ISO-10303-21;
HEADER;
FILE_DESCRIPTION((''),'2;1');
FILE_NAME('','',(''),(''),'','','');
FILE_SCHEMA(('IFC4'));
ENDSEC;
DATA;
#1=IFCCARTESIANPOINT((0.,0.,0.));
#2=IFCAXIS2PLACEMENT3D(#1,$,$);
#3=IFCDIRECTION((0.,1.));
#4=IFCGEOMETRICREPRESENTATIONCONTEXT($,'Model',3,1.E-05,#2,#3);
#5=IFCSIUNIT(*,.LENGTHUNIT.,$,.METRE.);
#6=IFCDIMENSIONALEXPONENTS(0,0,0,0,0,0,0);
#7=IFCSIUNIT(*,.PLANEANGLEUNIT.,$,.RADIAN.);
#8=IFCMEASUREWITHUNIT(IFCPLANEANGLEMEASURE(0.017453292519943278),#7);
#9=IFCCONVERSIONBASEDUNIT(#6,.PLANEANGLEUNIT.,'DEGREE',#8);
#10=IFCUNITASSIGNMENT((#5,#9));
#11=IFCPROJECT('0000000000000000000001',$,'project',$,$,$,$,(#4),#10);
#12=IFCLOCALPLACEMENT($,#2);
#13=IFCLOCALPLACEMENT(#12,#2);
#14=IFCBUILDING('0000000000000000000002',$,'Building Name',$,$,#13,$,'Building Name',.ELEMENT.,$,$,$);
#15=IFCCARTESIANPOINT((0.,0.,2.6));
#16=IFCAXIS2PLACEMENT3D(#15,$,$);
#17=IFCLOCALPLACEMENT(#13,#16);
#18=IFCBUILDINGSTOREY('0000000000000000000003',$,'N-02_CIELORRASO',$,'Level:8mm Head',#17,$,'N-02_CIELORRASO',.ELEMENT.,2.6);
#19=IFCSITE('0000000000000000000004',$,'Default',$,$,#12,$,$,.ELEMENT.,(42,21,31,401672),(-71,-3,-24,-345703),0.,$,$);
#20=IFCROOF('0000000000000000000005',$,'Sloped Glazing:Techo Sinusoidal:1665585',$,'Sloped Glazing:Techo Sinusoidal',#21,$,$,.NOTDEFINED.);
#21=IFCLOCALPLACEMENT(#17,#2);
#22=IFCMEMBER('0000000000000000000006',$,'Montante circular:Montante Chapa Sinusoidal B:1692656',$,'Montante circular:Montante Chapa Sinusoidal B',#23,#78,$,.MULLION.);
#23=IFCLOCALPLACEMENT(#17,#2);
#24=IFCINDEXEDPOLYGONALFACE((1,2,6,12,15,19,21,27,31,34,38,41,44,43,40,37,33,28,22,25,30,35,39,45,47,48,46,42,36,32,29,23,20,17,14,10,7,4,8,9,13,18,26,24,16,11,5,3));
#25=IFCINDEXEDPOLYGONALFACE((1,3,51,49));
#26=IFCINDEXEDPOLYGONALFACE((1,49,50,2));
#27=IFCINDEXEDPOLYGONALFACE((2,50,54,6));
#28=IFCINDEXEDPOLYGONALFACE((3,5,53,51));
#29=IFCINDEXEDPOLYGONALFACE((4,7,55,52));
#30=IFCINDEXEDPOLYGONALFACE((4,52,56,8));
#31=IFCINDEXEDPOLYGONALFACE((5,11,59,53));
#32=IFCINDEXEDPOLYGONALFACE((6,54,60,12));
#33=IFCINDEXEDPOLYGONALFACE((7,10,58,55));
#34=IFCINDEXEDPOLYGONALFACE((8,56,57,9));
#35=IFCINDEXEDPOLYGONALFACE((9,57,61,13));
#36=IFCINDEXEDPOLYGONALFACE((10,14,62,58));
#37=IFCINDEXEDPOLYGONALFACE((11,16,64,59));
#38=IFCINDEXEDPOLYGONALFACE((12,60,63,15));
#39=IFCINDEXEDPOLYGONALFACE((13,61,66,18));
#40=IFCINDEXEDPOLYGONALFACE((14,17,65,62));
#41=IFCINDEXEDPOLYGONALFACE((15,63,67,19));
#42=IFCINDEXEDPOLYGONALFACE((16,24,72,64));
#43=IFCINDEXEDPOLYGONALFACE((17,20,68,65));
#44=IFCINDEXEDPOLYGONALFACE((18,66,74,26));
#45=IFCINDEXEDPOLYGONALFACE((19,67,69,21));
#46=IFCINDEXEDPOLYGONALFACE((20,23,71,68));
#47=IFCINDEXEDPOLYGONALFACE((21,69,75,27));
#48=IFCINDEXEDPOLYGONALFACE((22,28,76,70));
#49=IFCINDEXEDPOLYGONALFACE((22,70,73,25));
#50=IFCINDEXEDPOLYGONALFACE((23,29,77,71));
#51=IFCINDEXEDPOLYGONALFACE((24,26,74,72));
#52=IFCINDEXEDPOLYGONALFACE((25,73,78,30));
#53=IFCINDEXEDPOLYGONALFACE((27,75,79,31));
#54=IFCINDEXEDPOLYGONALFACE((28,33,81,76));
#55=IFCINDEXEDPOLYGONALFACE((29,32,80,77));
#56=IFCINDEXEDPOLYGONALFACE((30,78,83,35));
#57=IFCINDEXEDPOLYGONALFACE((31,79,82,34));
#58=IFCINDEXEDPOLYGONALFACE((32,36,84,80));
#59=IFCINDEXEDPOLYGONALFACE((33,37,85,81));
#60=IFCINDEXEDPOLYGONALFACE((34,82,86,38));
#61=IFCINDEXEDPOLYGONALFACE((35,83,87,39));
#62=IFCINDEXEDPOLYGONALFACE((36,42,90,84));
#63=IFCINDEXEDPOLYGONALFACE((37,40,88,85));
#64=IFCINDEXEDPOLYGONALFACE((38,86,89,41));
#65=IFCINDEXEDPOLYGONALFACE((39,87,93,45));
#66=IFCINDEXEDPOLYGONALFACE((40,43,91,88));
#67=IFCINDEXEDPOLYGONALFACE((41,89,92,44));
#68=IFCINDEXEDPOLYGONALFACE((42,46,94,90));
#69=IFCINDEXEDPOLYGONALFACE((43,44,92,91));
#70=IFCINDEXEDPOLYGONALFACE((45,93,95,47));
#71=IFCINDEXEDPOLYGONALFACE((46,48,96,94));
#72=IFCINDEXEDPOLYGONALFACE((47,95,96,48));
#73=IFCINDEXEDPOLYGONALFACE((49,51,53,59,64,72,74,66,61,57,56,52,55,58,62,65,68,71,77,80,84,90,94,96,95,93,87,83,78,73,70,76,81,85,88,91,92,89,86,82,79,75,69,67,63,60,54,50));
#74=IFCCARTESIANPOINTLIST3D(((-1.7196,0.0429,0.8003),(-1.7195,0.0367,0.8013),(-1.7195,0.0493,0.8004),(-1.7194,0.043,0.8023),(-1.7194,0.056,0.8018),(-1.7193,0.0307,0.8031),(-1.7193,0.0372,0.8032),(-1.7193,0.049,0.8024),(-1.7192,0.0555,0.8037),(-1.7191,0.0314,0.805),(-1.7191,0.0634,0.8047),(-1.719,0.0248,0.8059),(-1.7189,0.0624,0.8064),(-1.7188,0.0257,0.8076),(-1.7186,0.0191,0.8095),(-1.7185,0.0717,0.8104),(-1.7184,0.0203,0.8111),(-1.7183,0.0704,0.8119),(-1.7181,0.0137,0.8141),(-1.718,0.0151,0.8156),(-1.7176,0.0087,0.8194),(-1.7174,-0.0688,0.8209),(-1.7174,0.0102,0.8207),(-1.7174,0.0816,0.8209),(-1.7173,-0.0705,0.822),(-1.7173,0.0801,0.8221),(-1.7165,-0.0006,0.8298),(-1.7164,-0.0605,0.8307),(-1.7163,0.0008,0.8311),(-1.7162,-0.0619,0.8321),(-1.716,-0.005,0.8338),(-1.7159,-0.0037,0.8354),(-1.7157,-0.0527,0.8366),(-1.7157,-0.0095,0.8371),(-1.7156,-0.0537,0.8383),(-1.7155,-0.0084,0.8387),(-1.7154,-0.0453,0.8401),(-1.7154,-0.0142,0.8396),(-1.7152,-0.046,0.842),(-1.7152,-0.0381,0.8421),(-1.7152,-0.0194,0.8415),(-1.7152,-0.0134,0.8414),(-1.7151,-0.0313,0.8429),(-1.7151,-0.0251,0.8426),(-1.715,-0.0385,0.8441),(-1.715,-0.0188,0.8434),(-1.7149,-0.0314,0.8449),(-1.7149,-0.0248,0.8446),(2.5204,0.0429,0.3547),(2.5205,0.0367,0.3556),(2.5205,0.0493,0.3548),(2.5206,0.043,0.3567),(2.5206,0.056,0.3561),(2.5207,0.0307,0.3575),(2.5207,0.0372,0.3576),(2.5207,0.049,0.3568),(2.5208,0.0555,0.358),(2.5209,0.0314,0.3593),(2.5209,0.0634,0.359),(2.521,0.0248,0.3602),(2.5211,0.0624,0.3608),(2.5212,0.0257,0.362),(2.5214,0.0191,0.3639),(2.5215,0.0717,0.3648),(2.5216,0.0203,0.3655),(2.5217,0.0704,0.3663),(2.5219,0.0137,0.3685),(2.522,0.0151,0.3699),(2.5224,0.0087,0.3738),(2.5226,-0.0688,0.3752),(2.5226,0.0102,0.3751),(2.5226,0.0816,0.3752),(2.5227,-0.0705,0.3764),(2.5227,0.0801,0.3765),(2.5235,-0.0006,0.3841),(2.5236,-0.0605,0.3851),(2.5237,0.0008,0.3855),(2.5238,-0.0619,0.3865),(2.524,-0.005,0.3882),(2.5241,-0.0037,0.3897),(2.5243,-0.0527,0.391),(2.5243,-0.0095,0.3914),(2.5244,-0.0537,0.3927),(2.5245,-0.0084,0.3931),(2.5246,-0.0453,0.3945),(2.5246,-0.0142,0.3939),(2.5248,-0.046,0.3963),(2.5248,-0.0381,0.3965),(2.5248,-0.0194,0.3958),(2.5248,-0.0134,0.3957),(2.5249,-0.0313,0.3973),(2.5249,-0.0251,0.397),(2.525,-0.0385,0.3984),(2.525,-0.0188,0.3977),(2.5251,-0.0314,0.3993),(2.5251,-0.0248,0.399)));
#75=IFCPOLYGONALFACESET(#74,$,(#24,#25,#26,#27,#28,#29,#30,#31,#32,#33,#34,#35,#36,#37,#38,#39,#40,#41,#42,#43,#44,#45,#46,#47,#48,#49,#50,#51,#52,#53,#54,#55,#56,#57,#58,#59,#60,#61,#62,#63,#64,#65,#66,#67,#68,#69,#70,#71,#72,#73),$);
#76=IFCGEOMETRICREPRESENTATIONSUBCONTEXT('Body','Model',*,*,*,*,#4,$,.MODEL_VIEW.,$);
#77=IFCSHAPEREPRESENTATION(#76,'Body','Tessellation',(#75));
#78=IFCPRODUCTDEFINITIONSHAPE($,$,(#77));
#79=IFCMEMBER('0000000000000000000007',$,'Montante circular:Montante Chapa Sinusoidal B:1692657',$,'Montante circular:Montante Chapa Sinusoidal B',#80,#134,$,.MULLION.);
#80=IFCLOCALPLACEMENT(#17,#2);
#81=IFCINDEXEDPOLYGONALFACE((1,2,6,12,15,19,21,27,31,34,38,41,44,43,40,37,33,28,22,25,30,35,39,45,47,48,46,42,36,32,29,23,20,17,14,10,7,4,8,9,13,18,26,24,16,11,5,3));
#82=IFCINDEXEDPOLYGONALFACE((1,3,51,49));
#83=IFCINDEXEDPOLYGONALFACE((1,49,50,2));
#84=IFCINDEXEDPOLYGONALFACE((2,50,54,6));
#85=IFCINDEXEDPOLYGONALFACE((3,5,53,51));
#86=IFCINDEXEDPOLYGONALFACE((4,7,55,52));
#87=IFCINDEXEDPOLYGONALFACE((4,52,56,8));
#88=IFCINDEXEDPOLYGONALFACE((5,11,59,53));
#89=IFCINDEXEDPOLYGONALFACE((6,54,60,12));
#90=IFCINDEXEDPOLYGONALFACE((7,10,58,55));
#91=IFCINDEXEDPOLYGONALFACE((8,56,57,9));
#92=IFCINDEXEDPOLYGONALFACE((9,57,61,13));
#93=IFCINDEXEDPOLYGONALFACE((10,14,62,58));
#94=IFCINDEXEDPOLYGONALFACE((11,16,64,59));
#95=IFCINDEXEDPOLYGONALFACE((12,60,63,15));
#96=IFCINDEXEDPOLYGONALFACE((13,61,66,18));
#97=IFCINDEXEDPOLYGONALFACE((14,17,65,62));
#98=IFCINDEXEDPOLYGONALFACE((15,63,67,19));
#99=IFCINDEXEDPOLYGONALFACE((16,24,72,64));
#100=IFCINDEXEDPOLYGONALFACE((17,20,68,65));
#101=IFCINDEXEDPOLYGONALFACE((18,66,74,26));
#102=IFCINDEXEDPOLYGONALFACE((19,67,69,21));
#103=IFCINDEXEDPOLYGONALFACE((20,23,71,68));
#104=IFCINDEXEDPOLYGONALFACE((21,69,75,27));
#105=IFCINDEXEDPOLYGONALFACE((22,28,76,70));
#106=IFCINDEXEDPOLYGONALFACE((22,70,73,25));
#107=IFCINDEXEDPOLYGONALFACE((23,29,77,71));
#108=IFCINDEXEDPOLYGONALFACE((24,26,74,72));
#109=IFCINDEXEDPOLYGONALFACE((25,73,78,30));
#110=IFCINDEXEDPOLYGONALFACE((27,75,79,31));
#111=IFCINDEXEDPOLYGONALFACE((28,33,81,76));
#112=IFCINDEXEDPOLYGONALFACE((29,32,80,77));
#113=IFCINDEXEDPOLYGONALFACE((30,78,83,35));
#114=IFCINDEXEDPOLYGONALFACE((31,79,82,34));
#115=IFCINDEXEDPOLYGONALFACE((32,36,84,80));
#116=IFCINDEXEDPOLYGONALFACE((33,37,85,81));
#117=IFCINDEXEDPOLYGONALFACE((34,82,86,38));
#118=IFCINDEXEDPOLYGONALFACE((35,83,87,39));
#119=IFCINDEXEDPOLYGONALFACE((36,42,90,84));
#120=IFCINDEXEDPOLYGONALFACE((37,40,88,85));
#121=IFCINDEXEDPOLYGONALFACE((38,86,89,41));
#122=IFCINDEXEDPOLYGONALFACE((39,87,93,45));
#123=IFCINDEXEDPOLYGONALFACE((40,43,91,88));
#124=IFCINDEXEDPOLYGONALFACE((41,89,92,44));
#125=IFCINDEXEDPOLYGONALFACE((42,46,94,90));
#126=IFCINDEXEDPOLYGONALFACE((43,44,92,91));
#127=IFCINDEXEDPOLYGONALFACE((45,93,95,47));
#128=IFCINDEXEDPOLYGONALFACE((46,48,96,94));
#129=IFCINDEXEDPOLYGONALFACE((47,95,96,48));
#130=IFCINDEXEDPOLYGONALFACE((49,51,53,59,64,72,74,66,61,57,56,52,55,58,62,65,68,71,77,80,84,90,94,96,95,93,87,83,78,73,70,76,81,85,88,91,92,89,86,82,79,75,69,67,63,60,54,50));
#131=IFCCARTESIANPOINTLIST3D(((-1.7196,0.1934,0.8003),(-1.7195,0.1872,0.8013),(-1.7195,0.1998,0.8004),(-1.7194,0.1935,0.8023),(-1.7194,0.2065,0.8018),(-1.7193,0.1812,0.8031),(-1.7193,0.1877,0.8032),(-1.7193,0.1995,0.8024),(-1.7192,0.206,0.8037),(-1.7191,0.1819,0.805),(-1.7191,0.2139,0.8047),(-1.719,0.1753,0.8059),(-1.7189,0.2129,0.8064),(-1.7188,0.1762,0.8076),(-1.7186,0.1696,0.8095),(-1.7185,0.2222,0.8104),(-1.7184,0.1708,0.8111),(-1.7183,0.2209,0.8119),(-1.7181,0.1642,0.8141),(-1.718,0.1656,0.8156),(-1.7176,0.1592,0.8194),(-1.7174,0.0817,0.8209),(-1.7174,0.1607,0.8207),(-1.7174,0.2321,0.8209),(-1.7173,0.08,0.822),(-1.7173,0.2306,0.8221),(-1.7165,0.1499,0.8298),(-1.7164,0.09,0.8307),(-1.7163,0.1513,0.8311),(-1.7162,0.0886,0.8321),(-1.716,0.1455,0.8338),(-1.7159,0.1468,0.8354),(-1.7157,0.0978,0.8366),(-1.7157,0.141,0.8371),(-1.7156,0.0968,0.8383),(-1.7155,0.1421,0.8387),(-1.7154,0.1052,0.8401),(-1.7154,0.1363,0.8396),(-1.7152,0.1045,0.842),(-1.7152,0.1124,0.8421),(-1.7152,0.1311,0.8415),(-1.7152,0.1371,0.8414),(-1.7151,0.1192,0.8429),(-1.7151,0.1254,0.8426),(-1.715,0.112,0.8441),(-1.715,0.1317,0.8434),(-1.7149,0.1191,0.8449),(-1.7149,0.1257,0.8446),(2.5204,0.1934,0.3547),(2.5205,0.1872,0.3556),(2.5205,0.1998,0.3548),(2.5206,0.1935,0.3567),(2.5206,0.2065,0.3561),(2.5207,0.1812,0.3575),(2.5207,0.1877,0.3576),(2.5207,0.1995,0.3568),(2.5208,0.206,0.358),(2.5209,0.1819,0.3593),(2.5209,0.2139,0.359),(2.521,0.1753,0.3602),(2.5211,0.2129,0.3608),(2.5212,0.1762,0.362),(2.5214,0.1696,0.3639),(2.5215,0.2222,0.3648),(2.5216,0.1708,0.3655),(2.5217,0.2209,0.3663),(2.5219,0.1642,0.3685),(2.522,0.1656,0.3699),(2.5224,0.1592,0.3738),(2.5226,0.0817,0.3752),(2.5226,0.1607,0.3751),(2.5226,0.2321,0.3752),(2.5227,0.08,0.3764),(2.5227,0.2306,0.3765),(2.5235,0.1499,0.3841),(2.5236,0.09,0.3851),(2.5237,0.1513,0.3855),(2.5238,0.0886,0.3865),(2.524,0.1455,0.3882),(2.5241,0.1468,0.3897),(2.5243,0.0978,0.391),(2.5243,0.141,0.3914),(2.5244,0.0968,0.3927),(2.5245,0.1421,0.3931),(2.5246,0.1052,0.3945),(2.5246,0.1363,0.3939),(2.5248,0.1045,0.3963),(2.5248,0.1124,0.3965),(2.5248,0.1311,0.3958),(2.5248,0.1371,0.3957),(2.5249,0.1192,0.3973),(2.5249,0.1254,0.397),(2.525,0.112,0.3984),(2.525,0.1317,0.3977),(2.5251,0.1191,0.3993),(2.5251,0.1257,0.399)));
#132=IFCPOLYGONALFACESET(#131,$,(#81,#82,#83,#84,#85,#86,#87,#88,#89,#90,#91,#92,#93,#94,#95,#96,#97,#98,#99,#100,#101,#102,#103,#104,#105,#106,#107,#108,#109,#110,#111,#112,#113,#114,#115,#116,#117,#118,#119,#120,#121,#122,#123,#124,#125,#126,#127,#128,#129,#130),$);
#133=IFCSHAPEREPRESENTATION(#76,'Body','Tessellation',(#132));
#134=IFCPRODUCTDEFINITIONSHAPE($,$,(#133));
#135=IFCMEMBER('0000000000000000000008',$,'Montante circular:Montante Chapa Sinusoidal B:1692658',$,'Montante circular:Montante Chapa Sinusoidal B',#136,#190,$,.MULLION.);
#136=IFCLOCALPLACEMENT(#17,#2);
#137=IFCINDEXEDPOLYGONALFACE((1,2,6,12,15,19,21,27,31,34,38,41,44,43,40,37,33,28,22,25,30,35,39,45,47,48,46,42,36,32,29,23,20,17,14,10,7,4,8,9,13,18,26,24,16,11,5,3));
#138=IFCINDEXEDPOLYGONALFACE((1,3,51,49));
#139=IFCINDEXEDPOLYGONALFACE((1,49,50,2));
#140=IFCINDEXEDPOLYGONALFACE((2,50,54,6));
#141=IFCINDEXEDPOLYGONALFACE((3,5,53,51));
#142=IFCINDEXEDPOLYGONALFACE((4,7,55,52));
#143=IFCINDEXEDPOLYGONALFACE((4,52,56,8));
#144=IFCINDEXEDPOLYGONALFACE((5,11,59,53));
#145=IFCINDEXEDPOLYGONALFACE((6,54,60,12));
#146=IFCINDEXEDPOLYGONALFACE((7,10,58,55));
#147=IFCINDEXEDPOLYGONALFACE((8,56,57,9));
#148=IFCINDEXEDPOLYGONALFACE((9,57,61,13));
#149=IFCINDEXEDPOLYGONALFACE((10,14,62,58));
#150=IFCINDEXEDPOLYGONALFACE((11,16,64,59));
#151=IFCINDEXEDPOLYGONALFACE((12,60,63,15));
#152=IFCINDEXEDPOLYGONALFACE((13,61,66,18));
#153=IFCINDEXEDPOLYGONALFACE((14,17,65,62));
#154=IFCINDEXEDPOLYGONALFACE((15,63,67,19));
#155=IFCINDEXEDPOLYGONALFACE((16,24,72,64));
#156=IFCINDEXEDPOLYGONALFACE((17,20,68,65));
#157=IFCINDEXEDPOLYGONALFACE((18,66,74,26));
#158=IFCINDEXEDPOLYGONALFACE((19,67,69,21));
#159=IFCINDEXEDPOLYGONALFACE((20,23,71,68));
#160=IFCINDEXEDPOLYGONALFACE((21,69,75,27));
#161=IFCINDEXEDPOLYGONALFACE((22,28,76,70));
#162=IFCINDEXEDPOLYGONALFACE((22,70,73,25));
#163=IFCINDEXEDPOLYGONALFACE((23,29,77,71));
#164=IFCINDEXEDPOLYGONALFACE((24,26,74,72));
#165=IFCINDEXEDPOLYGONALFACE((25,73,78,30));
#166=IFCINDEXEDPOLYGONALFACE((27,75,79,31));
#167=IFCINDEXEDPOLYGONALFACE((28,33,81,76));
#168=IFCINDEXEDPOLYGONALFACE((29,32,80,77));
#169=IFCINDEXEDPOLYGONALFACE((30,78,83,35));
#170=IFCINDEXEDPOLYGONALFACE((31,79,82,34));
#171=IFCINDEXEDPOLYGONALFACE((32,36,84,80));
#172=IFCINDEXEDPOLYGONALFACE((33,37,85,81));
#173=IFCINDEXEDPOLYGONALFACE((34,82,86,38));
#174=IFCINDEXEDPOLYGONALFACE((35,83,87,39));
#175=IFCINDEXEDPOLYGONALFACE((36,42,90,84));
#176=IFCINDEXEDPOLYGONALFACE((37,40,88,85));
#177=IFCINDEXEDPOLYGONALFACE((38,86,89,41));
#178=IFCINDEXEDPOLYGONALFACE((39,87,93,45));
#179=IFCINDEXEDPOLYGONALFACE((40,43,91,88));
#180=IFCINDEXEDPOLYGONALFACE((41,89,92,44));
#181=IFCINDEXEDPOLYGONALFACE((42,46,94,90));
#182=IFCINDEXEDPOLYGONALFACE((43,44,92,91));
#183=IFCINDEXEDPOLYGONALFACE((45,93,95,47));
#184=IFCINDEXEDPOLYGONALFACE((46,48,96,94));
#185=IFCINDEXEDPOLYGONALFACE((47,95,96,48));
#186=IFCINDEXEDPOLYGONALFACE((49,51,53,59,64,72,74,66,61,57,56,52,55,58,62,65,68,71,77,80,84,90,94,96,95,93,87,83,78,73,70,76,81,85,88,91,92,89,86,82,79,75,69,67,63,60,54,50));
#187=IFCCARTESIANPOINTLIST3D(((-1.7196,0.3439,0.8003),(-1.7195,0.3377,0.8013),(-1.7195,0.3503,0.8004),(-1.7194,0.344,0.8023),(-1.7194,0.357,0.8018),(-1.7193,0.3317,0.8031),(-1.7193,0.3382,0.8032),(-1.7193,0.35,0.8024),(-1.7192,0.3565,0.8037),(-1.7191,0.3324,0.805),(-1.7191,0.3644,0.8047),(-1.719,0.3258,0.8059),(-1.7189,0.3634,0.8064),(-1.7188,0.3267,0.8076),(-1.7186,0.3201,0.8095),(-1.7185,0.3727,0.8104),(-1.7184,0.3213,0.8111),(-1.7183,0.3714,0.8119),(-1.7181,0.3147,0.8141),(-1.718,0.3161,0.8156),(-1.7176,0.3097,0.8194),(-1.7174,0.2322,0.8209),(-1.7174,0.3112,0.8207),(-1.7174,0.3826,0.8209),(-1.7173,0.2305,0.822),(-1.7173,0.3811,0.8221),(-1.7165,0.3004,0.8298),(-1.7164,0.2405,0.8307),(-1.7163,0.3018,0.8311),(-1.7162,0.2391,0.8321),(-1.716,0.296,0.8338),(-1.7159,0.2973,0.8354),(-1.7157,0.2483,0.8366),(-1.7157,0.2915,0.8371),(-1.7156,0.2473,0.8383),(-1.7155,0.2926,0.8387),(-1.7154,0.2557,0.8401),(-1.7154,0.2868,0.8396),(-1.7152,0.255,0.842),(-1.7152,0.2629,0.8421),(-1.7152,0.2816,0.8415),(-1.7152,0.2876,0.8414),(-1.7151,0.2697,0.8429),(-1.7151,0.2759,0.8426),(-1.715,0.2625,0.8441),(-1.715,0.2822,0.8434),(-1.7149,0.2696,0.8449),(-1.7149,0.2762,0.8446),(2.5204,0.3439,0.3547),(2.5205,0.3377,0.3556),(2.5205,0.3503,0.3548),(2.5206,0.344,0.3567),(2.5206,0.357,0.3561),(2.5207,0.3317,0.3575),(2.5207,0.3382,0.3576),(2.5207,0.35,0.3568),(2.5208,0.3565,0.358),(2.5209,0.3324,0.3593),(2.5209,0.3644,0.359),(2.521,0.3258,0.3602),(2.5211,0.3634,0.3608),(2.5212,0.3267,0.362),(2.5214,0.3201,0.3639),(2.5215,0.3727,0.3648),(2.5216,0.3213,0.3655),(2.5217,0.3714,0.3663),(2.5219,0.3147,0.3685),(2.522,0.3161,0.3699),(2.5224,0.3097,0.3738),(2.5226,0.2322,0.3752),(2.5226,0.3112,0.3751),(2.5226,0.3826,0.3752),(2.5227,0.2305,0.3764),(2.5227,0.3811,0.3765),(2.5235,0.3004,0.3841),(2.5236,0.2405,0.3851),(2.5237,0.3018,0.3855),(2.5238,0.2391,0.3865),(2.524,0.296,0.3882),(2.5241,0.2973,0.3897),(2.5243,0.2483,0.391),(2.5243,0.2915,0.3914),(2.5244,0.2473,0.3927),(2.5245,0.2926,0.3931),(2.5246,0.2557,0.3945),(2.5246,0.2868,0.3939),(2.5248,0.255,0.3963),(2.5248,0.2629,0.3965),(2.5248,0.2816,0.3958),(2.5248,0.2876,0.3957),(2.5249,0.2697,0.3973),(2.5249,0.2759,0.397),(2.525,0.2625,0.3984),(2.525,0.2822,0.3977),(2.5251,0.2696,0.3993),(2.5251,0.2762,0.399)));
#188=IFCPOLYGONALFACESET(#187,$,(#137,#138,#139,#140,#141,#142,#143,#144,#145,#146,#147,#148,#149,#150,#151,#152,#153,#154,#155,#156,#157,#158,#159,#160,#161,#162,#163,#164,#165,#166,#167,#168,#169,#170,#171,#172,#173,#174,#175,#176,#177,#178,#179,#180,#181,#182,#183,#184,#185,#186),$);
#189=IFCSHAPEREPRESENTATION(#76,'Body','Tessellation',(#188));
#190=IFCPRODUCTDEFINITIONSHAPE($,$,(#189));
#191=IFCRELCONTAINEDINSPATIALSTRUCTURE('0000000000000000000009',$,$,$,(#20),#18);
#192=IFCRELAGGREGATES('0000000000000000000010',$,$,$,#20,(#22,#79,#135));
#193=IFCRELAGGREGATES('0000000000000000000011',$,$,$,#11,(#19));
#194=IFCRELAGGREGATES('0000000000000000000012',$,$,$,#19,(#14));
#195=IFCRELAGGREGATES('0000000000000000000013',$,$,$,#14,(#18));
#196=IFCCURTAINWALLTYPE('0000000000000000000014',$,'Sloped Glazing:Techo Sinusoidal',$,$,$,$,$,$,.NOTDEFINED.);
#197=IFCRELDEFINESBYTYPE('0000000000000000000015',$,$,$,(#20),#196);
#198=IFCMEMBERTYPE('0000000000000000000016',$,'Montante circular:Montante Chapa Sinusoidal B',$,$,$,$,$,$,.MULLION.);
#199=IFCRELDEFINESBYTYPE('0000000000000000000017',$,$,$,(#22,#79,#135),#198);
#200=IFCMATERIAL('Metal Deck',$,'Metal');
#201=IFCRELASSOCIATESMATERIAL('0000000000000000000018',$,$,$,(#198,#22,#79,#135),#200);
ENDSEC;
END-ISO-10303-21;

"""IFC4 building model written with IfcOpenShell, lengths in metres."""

from ifc_helpers import new_model, entity, si_unit, converted_unit, direction, frame, origin, place, context, subcontext, project, spatial, indexed_curve, outline, extrude, source, transform, mapped, material, type_object, type_shapes, element, aggregate, save


model = new_model("IFC4")

# Units and contexts
model_context = context("Model", 3, precision=1e-05, world=origin(), true_north=direction((0.0, 1.0)))
body_context = subcontext(model_context, "Body", "Model", "MODEL_VIEW")
ifc_project = project(units=[si_unit("LENGTHUNIT", "METRE"), converted_unit("PLANEANGLEUNIT", "DEGREE", entity("IfcPlaneAngleMeasure", 0.017453292519943278), si_unit("PLANEANGLEUNIT", "RADIAN"), dimensions=[0, 0, 0, 0, 0, 0, 0])], contexts=[model_context])

# Site, building, storey
site_placement = place(None, origin())
site = spatial("IfcSite", under=ifc_project, at=site_placement, Name="Default", CompositionType="ELEMENT", RefLatitude=(42, 21, 31, 401672), RefLongitude=(-71, -3, -24, -345703), RefElevation=0.0)
building_placement = place(site_placement, origin())
building = spatial("IfcBuilding", under=site, at=building_placement, Name="Building Name", LongName="Building Name", CompositionType="ELEMENT")
storey_placement = place(building_placement, frame((0.0, 0.0, 2.6)))
storey = spatial("IfcBuildingStorey", under=building, at=storey_placement, Name="N-02_CIELORRASO", ObjectType="Level:8mm Head", LongName="N-02_CIELORRASO", CompositionType="ELEMENT", Elevation=2.6)

# Roof, members
curtain_wall_type = type_object("IfcCurtainWallType", Name="Sloped Glazing:Techo Sinusoidal", PredefinedType="NOTDEFINED")
roof_placement = place(storey_placement, frame((0.0, 0.0, -2.6)))
roof = element("IfcRoof", 1, at=roof_placement, inside=storey, type_object=curtain_wall_type, Name="Sloped Glazing:Techo Sinusoidal:1665585", ObjectType="Sloped Glazing:Techo Sinusoidal", PredefinedType="NOTDEFINED")
ifc_material = material(Name="Metal Deck", Category="Metal")
member_type = type_object("IfcMemberType", Name="Montante circular:Montante Chapa Sinusoidal B", PredefinedType="MULLION", material=ifc_material)
shared_shape = source(origin(), body_context, "Body", "SweptSolid", [
    extrude(outline(indexed_curve([(0.0595, -0.0443), (0.0615, -0.0443), (0.0603, -0.031), (0.0572, -0.0213), (0.053, -0.0138), (0.0481, -0.0078), (0.0427, -0.003), (0.0372, 0.0005), (0.0315, 0.0029), (0.0259, 0.0044), (0.0203, 0.0051), (0.0146, 0.005), (0.0084, 0.0041), (-0.0053, 0.0009), (-0.0123, -0.0005), (-0.0191, -0.0012), (-0.0256, -0.001), (-0.0317, 0.0001), (-0.0375, 0.0019), (-0.0428, 0.0046), (-0.0477, 0.0081), (-0.0522, 0.0128), (-0.0563, 0.0191), (-0.0597, 0.0282), (-0.0617, 0.0421), (-0.0637, 0.042), (-0.0616, 0.0277), (-0.0581, 0.0182), (-0.0537, 0.0116), (-0.049, 0.0066), (-0.0438, 0.0028), (-0.0382, 0.0001), (-0.0322, -0.0019), (-0.0258, -0.003), (-0.019, -0.0032), (-0.012, -0.0025), (-0.0048, -0.0011), (0.0088, 0.0021), (0.0147, 0.003), (0.0202, 0.0031), (0.0255, 0.0024), (0.0309, 0.001), (0.0362, -0.0013), (0.0415, -0.0046), (0.0466, -0.0092), (0.0513, -0.0149), (0.0554, -0.0221), (0.0584, -0.0314), (0.0595, -0.0443)], self_intersect=False)), frame((-0.007, 0.0228, -4.2634), z_axis=(0.0, 0.0, 1.0), x_axis=(-0.819152, -0.573576, 0.0)), (0.0, 0.0, 1.0), 4.2634),
])
type_shapes(member_type, [shared_shape])
member_1_placement = place(roof_placement, frame((-1.7148, 0.0124, 3.4456), z_axis=(-0.994522, 0.0, 0.104528), x_axis=(0.0, 1.0, 0.0)))
member_1 = element("IfcMember", 2, at=member_1_placement, type_object=member_type, material=ifc_material, Name="Montante circular:Montante Chapa Sinusoidal B:1692656", ObjectType="Montante circular:Montante Chapa Sinusoidal B", PredefinedType="MULLION", context=body_context, shape_type="MappedRepresentation", body=[
    mapped(shared_shape, transform((0.0, 0.0, 0.0), scale=1.0)),
])
member_2_placement = place(roof_placement, frame((-1.7148, 0.1629, 3.4456), z_axis=(-0.994522, 0.0, 0.104528), x_axis=(0.0, 1.0, 0.0)))
member_2 = element("IfcMember", 3, at=member_2_placement, type_object=member_type, material=ifc_material, Name="Montante circular:Montante Chapa Sinusoidal B:1692657", ObjectType="Montante circular:Montante Chapa Sinusoidal B", PredefinedType="MULLION", context=body_context, shape_type="MappedRepresentation", body=[
    mapped(shared_shape, transform((0.0, 0.0, 0.0), scale=1.0)),
])
member_3_placement = place(roof_placement, frame((-1.7148, 0.3134, 3.4456), z_axis=(-0.994522, 0.0, 0.104528), x_axis=(0.0, 1.0, 0.0)))
member_3 = element("IfcMember", 4, at=member_3_placement, type_object=member_type, material=ifc_material, Name="Montante circular:Montante Chapa Sinusoidal B:1692658", ObjectType="Montante circular:Montante Chapa Sinusoidal B", PredefinedType="MULLION", context=body_context, shape_type="MappedRepresentation", body=[
    mapped(shared_shape, transform((0.0, 0.0, 0.0), scale=1.0)),
])
aggregate(roof, [member_1, member_2, member_3])

save(model, "model.ifc")
